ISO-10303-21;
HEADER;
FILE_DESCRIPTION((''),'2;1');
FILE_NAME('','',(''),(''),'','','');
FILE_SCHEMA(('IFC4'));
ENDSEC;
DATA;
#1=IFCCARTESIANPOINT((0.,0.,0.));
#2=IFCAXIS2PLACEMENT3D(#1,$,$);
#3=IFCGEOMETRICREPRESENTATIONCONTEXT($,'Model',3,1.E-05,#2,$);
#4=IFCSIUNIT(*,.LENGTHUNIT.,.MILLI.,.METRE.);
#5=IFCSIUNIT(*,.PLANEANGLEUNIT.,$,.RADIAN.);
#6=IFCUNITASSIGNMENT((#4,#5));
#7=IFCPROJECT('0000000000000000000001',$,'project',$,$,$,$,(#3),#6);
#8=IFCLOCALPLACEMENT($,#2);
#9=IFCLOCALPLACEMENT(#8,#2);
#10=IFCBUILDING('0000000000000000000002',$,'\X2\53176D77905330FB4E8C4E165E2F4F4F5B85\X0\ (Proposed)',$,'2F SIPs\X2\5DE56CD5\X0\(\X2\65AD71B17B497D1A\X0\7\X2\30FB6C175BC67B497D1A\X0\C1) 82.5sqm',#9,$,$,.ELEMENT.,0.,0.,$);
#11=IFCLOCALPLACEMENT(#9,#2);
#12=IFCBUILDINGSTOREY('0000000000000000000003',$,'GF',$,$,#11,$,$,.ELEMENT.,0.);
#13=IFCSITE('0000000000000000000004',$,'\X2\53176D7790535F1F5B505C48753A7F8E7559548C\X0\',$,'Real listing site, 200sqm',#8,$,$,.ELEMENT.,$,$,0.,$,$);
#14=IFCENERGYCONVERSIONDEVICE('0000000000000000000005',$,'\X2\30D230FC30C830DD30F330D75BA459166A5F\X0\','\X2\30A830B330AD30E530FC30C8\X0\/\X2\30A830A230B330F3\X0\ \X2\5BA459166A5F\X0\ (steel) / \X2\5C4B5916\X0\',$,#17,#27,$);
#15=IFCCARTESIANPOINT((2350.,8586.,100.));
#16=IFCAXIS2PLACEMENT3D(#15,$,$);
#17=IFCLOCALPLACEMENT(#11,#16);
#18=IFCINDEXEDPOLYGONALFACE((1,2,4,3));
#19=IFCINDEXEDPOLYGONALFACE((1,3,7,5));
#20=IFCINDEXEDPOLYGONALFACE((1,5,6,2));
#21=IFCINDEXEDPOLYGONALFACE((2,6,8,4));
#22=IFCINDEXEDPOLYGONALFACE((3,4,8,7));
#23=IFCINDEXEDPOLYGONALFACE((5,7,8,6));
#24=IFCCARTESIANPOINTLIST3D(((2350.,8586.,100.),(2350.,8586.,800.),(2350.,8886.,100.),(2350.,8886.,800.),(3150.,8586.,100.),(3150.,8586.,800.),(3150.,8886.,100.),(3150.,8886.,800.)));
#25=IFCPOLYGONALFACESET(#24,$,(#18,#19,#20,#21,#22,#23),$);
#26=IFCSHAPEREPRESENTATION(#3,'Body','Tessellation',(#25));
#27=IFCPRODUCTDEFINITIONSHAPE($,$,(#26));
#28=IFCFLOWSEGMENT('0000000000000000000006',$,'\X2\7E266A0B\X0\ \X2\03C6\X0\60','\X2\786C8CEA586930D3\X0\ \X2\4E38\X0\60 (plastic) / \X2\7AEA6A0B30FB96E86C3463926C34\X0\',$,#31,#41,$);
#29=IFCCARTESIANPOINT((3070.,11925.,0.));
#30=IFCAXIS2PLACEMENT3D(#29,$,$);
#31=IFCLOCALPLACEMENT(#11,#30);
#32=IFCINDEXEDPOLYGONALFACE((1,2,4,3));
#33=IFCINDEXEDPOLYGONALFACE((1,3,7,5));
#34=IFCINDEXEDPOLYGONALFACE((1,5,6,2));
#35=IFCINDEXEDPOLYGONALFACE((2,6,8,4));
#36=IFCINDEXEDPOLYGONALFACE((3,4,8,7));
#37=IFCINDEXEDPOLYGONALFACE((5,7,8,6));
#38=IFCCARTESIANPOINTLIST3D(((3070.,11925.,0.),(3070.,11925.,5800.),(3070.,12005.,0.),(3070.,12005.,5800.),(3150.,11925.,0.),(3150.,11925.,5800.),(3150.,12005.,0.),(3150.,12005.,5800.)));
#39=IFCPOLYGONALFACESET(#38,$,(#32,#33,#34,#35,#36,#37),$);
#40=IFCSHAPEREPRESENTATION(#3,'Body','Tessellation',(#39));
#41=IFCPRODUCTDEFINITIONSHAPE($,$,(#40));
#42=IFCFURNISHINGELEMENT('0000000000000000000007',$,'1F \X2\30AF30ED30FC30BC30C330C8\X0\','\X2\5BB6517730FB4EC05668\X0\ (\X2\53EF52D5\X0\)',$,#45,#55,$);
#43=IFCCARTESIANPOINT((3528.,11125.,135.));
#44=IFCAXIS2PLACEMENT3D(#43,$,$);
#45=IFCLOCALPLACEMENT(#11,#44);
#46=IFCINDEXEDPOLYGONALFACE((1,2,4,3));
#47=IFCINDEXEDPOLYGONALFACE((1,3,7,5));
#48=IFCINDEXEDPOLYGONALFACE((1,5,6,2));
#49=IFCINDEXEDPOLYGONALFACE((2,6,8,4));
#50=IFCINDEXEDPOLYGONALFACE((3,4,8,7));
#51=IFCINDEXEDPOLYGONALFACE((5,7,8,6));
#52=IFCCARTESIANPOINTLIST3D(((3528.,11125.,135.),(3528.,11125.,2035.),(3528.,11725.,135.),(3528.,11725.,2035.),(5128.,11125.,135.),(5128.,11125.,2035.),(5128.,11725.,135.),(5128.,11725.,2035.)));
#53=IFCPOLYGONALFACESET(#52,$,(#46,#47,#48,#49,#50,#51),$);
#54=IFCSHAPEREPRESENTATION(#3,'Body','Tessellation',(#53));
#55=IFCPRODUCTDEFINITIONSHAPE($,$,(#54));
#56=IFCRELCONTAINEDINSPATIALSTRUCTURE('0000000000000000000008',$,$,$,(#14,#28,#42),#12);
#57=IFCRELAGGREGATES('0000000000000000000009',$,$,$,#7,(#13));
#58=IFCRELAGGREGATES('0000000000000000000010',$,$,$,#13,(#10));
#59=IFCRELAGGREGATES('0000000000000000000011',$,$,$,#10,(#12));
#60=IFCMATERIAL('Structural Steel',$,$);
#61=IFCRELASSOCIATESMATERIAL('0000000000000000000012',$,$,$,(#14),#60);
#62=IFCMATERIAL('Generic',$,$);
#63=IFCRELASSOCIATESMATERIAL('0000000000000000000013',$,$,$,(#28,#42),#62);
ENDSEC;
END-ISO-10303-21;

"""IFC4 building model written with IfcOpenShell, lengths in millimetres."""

from ifc_helpers import new_model, si_unit, frame, frame_2d, origin, place, context, project, spatial, rectangle, extrude, material, element, save


model = new_model("IFC4")

# Units and contexts
model_context = context("Model", 3, precision=1e-05, world=origin())
ifc_project = project(units=[si_unit("LENGTHUNIT", "METRE", prefix="MILLI"), si_unit("PLANEANGLEUNIT", "RADIAN")], contexts=[model_context])

# Site, building, storey
site_placement = place(None, origin())
site = spatial("IfcSite", under=ifc_project, at=site_placement, Name="北海道弟子屈町美留和", ObjectType="Real listing site, 200sqm", CompositionType="ELEMENT", RefElevation=0.0)
building_placement = place(site_placement, origin())
building = spatial("IfcBuilding", under=site, at=building_placement, Name="北海道・二世帯住宅 (Proposed)", ObjectType="2F SIPs工法(断熱等級7・気密等級C1) 82.5sqm", CompositionType="ELEMENT", ElevationOfRefHeight=0.0, ElevationOfTerrain=0.0)
storey_placement = place(building_placement, origin())
storey = spatial("IfcBuildingStorey", under=building, at=storey_placement, Name="GF", CompositionType="ELEMENT", Elevation=0.0)

# Shared definitions
ifc_material_1 = material(Name="Generic")

# Energy conversion device
ifc_material_2 = material(Name="Structural Steel")
energy_conversion_device_placement = place(storey_placement, frame((2350.0, 8586.0, 100.0)))
element("IfcEnergyConversionDevice", 1, at=energy_conversion_device_placement, inside=storey, material=ifc_material_2, Name="ヒートポンプ室外機", Description="エコキュート/エアコン 室外機 (steel) / 屋外", context=model_context, shape_type="SweptSolid", body=[
    extrude(rectangle(XDim=800.0, YDim=300.0, at=frame_2d((400.0, 150.0))), frame((2350.0, 8586.0, 100.0)), (0.0, 0.0, 1.0), 700.0),
])

# Flow segment
flow_segment_placement = place(storey_placement, frame((3070.0, 11925.0, 0.0)))
element("IfcFlowSegment", 2, at=flow_segment_placement, inside=storey, material=ifc_material_1, Name="縦樋 φ60", Description="硬質塩ビ 丸60 (plastic) / 竪樋・雨水排水", context=model_context, shape_type="SweptSolid", body=[
    extrude(rectangle(XDim=80.0, YDim=80.0, at=frame_2d((40.0, 40.0))), frame((3070.0, 11925.0, 0.0)), (0.0, 0.0, 1.0), 5800.0),
])

# Furnishing element
furnishing_placement = place(storey_placement, frame((3528.0, 11125.0, 135.0)))
element("IfcFurnishingElement", 3, at=furnishing_placement, inside=storey, material=ifc_material_1, Name="1F クローゼット", Description="家具・什器 (可動)", context=model_context, shape_type="SweptSolid", body=[
    extrude(rectangle(XDim=1600.0, YDim=600.0, at=frame_2d((800.0, 300.0))), frame((3528.0, 11125.0, 135.0)), (0.0, 0.0, 1.0), 1900.0),
])

save(model, "model.ifc")
